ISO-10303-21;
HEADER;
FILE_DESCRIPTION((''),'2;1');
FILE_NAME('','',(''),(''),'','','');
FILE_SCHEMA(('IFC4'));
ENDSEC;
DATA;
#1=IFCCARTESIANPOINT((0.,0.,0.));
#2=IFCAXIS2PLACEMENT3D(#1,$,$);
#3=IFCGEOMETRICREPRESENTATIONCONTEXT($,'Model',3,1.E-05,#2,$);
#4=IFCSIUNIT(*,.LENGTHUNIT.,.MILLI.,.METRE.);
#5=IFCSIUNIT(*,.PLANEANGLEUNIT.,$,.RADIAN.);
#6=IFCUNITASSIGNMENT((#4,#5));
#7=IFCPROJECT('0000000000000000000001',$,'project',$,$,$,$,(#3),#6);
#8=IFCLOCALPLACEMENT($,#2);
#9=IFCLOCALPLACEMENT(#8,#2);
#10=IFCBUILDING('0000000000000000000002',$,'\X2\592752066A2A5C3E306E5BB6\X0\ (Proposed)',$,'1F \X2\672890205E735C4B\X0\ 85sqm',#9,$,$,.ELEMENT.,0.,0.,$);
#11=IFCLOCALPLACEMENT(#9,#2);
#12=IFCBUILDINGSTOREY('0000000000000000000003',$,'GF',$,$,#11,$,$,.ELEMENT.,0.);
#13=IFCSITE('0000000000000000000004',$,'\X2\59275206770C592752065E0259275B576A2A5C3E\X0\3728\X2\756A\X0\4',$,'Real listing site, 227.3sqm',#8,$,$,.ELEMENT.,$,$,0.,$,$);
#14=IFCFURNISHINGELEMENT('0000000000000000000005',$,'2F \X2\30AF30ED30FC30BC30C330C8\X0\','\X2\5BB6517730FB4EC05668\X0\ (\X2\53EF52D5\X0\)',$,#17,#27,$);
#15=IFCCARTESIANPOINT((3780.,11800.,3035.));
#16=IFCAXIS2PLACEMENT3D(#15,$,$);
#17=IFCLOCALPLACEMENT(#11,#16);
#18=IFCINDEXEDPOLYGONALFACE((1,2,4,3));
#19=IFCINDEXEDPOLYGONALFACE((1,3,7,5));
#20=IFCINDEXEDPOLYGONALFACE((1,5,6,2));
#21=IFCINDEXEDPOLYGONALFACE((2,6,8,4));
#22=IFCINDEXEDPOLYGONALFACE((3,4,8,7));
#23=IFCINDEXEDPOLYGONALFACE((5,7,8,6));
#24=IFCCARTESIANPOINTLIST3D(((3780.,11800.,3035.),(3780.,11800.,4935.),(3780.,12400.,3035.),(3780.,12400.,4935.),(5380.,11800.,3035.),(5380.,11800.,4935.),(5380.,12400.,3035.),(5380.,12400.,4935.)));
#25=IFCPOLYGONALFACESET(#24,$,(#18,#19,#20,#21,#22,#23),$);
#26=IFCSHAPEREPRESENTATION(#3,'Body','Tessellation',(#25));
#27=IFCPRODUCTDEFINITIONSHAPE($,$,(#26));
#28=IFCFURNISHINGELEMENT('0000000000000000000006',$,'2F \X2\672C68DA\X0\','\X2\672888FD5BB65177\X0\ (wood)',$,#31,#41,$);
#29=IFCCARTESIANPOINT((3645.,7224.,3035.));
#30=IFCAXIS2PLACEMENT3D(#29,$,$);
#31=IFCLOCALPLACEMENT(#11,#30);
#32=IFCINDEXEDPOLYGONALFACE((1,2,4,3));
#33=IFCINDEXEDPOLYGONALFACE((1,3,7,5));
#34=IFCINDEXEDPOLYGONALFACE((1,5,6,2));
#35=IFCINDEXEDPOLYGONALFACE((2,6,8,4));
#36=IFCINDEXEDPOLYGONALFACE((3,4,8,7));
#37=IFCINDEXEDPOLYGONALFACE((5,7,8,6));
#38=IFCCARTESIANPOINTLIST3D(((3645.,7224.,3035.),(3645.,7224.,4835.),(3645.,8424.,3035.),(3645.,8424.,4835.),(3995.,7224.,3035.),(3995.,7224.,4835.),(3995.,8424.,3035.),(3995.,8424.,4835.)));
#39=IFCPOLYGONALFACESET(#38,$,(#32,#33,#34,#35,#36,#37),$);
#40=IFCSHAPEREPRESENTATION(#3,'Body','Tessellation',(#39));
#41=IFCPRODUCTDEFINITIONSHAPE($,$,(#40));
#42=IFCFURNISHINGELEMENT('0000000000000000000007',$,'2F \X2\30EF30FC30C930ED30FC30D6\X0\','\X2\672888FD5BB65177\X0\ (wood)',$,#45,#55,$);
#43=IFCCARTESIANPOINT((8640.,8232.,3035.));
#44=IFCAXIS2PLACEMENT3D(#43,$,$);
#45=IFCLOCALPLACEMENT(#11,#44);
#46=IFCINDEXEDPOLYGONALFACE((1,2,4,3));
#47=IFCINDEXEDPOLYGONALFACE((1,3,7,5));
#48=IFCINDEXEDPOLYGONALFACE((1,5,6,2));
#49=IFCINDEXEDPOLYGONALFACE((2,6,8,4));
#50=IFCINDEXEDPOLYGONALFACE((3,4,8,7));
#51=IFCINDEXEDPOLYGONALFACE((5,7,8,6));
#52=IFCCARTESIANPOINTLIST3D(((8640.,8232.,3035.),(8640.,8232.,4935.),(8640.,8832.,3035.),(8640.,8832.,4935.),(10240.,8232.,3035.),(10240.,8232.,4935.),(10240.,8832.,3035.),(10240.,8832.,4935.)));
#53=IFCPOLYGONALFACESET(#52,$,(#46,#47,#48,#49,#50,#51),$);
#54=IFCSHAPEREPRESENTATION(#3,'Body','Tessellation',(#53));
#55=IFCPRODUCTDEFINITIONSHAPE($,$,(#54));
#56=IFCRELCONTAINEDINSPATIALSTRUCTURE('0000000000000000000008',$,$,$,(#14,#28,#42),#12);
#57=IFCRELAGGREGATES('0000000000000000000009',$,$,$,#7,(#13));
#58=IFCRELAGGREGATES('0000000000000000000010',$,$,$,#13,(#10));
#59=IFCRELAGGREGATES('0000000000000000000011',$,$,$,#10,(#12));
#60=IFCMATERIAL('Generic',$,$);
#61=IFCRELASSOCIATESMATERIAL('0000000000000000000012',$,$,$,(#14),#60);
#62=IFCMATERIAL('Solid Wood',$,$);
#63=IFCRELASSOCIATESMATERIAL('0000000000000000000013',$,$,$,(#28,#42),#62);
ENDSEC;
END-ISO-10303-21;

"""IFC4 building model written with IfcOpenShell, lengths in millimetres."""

from ifc_helpers import new_model, si_unit, frame, frame_2d, origin, place, context, project, spatial, rectangle, extrude, material, element, save


model = new_model("IFC4")

# Units and contexts
model_context = context("Model", 3, precision=1e-05, world=origin())
ifc_project = project(units=[si_unit("LENGTHUNIT", "METRE", prefix="MILLI"), si_unit("PLANEANGLEUNIT", "RADIAN")], contexts=[model_context])

# Site, building, storey
site_placement = place(None, origin())
site = spatial("IfcSite", under=ifc_project, at=site_placement, Name="大分県大分市大字横尾3728番4", ObjectType="Real listing site, 227.3sqm", CompositionType="ELEMENT", RefElevation=0.0)
building_placement = place(site_placement, origin())
building = spatial("IfcBuilding", under=site, at=building_placement, Name="大分横尾の家 (Proposed)", ObjectType="1F 木造平屋 85sqm", CompositionType="ELEMENT", ElevationOfRefHeight=0.0, ElevationOfTerrain=0.0)
storey_placement = place(building_placement, origin())
storey = spatial("IfcBuildingStorey", under=building, at=storey_placement, Name="GF", CompositionType="ELEMENT", Elevation=0.0)

# Shared definitions
ifc_material_1 = material(Name="Solid Wood")

# Shared definitions
ifc_material_2 = material(Name="Generic")

# Furnishing elements
furnishing_1_placement = place(storey_placement, frame((3780.0, 11800.0, 3035.0)))
element("IfcFurnishingElement", 1, at=furnishing_1_placement, inside=storey, material=ifc_material_2, Name="2F クローゼット", Description="家具・什器 (可動)", context=model_context, shape_type="SweptSolid", body=[
    extrude(rectangle(XDim=1600.0, YDim=600.0, at=frame_2d((800.0, 300.0))), frame((3780.0, 11800.0, 3035.0)), (0.0, 0.0, 1.0), 1900.0),
])
furnishing_2_placement = place(storey_placement, frame((3645.0, 7224.0, 3035.0)))
element("IfcFurnishingElement", 2, at=furnishing_2_placement, inside=storey, material=ifc_material_1, Name="2F 本棚", Description="木製家具 (wood)", context=model_context, shape_type="SweptSolid", body=[
    extrude(rectangle(XDim=350.0, YDim=1200.0, at=frame_2d((175.0, 600.0))), frame((3645.0, 7224.0, 3035.0)), (0.0, 0.0, 1.0), 1800.0),
])
furnishing_3_placement = place(storey_placement, frame((8640.0, 8232.0, 3035.0)))
element("IfcFurnishingElement", 3, at=furnishing_3_placement, inside=storey, material=ifc_material_1, Name="2F ワードローブ", Description="木製家具 (wood)", context=model_context, shape_type="SweptSolid", body=[
    extrude(rectangle(XDim=1600.0, YDim=600.0, at=frame_2d((800.0, 300.0))), frame((8640.0, 8232.0, 3035.0)), (0.0, 0.0, 1.0), 1900.0),
])

save(model, "model.ifc")
